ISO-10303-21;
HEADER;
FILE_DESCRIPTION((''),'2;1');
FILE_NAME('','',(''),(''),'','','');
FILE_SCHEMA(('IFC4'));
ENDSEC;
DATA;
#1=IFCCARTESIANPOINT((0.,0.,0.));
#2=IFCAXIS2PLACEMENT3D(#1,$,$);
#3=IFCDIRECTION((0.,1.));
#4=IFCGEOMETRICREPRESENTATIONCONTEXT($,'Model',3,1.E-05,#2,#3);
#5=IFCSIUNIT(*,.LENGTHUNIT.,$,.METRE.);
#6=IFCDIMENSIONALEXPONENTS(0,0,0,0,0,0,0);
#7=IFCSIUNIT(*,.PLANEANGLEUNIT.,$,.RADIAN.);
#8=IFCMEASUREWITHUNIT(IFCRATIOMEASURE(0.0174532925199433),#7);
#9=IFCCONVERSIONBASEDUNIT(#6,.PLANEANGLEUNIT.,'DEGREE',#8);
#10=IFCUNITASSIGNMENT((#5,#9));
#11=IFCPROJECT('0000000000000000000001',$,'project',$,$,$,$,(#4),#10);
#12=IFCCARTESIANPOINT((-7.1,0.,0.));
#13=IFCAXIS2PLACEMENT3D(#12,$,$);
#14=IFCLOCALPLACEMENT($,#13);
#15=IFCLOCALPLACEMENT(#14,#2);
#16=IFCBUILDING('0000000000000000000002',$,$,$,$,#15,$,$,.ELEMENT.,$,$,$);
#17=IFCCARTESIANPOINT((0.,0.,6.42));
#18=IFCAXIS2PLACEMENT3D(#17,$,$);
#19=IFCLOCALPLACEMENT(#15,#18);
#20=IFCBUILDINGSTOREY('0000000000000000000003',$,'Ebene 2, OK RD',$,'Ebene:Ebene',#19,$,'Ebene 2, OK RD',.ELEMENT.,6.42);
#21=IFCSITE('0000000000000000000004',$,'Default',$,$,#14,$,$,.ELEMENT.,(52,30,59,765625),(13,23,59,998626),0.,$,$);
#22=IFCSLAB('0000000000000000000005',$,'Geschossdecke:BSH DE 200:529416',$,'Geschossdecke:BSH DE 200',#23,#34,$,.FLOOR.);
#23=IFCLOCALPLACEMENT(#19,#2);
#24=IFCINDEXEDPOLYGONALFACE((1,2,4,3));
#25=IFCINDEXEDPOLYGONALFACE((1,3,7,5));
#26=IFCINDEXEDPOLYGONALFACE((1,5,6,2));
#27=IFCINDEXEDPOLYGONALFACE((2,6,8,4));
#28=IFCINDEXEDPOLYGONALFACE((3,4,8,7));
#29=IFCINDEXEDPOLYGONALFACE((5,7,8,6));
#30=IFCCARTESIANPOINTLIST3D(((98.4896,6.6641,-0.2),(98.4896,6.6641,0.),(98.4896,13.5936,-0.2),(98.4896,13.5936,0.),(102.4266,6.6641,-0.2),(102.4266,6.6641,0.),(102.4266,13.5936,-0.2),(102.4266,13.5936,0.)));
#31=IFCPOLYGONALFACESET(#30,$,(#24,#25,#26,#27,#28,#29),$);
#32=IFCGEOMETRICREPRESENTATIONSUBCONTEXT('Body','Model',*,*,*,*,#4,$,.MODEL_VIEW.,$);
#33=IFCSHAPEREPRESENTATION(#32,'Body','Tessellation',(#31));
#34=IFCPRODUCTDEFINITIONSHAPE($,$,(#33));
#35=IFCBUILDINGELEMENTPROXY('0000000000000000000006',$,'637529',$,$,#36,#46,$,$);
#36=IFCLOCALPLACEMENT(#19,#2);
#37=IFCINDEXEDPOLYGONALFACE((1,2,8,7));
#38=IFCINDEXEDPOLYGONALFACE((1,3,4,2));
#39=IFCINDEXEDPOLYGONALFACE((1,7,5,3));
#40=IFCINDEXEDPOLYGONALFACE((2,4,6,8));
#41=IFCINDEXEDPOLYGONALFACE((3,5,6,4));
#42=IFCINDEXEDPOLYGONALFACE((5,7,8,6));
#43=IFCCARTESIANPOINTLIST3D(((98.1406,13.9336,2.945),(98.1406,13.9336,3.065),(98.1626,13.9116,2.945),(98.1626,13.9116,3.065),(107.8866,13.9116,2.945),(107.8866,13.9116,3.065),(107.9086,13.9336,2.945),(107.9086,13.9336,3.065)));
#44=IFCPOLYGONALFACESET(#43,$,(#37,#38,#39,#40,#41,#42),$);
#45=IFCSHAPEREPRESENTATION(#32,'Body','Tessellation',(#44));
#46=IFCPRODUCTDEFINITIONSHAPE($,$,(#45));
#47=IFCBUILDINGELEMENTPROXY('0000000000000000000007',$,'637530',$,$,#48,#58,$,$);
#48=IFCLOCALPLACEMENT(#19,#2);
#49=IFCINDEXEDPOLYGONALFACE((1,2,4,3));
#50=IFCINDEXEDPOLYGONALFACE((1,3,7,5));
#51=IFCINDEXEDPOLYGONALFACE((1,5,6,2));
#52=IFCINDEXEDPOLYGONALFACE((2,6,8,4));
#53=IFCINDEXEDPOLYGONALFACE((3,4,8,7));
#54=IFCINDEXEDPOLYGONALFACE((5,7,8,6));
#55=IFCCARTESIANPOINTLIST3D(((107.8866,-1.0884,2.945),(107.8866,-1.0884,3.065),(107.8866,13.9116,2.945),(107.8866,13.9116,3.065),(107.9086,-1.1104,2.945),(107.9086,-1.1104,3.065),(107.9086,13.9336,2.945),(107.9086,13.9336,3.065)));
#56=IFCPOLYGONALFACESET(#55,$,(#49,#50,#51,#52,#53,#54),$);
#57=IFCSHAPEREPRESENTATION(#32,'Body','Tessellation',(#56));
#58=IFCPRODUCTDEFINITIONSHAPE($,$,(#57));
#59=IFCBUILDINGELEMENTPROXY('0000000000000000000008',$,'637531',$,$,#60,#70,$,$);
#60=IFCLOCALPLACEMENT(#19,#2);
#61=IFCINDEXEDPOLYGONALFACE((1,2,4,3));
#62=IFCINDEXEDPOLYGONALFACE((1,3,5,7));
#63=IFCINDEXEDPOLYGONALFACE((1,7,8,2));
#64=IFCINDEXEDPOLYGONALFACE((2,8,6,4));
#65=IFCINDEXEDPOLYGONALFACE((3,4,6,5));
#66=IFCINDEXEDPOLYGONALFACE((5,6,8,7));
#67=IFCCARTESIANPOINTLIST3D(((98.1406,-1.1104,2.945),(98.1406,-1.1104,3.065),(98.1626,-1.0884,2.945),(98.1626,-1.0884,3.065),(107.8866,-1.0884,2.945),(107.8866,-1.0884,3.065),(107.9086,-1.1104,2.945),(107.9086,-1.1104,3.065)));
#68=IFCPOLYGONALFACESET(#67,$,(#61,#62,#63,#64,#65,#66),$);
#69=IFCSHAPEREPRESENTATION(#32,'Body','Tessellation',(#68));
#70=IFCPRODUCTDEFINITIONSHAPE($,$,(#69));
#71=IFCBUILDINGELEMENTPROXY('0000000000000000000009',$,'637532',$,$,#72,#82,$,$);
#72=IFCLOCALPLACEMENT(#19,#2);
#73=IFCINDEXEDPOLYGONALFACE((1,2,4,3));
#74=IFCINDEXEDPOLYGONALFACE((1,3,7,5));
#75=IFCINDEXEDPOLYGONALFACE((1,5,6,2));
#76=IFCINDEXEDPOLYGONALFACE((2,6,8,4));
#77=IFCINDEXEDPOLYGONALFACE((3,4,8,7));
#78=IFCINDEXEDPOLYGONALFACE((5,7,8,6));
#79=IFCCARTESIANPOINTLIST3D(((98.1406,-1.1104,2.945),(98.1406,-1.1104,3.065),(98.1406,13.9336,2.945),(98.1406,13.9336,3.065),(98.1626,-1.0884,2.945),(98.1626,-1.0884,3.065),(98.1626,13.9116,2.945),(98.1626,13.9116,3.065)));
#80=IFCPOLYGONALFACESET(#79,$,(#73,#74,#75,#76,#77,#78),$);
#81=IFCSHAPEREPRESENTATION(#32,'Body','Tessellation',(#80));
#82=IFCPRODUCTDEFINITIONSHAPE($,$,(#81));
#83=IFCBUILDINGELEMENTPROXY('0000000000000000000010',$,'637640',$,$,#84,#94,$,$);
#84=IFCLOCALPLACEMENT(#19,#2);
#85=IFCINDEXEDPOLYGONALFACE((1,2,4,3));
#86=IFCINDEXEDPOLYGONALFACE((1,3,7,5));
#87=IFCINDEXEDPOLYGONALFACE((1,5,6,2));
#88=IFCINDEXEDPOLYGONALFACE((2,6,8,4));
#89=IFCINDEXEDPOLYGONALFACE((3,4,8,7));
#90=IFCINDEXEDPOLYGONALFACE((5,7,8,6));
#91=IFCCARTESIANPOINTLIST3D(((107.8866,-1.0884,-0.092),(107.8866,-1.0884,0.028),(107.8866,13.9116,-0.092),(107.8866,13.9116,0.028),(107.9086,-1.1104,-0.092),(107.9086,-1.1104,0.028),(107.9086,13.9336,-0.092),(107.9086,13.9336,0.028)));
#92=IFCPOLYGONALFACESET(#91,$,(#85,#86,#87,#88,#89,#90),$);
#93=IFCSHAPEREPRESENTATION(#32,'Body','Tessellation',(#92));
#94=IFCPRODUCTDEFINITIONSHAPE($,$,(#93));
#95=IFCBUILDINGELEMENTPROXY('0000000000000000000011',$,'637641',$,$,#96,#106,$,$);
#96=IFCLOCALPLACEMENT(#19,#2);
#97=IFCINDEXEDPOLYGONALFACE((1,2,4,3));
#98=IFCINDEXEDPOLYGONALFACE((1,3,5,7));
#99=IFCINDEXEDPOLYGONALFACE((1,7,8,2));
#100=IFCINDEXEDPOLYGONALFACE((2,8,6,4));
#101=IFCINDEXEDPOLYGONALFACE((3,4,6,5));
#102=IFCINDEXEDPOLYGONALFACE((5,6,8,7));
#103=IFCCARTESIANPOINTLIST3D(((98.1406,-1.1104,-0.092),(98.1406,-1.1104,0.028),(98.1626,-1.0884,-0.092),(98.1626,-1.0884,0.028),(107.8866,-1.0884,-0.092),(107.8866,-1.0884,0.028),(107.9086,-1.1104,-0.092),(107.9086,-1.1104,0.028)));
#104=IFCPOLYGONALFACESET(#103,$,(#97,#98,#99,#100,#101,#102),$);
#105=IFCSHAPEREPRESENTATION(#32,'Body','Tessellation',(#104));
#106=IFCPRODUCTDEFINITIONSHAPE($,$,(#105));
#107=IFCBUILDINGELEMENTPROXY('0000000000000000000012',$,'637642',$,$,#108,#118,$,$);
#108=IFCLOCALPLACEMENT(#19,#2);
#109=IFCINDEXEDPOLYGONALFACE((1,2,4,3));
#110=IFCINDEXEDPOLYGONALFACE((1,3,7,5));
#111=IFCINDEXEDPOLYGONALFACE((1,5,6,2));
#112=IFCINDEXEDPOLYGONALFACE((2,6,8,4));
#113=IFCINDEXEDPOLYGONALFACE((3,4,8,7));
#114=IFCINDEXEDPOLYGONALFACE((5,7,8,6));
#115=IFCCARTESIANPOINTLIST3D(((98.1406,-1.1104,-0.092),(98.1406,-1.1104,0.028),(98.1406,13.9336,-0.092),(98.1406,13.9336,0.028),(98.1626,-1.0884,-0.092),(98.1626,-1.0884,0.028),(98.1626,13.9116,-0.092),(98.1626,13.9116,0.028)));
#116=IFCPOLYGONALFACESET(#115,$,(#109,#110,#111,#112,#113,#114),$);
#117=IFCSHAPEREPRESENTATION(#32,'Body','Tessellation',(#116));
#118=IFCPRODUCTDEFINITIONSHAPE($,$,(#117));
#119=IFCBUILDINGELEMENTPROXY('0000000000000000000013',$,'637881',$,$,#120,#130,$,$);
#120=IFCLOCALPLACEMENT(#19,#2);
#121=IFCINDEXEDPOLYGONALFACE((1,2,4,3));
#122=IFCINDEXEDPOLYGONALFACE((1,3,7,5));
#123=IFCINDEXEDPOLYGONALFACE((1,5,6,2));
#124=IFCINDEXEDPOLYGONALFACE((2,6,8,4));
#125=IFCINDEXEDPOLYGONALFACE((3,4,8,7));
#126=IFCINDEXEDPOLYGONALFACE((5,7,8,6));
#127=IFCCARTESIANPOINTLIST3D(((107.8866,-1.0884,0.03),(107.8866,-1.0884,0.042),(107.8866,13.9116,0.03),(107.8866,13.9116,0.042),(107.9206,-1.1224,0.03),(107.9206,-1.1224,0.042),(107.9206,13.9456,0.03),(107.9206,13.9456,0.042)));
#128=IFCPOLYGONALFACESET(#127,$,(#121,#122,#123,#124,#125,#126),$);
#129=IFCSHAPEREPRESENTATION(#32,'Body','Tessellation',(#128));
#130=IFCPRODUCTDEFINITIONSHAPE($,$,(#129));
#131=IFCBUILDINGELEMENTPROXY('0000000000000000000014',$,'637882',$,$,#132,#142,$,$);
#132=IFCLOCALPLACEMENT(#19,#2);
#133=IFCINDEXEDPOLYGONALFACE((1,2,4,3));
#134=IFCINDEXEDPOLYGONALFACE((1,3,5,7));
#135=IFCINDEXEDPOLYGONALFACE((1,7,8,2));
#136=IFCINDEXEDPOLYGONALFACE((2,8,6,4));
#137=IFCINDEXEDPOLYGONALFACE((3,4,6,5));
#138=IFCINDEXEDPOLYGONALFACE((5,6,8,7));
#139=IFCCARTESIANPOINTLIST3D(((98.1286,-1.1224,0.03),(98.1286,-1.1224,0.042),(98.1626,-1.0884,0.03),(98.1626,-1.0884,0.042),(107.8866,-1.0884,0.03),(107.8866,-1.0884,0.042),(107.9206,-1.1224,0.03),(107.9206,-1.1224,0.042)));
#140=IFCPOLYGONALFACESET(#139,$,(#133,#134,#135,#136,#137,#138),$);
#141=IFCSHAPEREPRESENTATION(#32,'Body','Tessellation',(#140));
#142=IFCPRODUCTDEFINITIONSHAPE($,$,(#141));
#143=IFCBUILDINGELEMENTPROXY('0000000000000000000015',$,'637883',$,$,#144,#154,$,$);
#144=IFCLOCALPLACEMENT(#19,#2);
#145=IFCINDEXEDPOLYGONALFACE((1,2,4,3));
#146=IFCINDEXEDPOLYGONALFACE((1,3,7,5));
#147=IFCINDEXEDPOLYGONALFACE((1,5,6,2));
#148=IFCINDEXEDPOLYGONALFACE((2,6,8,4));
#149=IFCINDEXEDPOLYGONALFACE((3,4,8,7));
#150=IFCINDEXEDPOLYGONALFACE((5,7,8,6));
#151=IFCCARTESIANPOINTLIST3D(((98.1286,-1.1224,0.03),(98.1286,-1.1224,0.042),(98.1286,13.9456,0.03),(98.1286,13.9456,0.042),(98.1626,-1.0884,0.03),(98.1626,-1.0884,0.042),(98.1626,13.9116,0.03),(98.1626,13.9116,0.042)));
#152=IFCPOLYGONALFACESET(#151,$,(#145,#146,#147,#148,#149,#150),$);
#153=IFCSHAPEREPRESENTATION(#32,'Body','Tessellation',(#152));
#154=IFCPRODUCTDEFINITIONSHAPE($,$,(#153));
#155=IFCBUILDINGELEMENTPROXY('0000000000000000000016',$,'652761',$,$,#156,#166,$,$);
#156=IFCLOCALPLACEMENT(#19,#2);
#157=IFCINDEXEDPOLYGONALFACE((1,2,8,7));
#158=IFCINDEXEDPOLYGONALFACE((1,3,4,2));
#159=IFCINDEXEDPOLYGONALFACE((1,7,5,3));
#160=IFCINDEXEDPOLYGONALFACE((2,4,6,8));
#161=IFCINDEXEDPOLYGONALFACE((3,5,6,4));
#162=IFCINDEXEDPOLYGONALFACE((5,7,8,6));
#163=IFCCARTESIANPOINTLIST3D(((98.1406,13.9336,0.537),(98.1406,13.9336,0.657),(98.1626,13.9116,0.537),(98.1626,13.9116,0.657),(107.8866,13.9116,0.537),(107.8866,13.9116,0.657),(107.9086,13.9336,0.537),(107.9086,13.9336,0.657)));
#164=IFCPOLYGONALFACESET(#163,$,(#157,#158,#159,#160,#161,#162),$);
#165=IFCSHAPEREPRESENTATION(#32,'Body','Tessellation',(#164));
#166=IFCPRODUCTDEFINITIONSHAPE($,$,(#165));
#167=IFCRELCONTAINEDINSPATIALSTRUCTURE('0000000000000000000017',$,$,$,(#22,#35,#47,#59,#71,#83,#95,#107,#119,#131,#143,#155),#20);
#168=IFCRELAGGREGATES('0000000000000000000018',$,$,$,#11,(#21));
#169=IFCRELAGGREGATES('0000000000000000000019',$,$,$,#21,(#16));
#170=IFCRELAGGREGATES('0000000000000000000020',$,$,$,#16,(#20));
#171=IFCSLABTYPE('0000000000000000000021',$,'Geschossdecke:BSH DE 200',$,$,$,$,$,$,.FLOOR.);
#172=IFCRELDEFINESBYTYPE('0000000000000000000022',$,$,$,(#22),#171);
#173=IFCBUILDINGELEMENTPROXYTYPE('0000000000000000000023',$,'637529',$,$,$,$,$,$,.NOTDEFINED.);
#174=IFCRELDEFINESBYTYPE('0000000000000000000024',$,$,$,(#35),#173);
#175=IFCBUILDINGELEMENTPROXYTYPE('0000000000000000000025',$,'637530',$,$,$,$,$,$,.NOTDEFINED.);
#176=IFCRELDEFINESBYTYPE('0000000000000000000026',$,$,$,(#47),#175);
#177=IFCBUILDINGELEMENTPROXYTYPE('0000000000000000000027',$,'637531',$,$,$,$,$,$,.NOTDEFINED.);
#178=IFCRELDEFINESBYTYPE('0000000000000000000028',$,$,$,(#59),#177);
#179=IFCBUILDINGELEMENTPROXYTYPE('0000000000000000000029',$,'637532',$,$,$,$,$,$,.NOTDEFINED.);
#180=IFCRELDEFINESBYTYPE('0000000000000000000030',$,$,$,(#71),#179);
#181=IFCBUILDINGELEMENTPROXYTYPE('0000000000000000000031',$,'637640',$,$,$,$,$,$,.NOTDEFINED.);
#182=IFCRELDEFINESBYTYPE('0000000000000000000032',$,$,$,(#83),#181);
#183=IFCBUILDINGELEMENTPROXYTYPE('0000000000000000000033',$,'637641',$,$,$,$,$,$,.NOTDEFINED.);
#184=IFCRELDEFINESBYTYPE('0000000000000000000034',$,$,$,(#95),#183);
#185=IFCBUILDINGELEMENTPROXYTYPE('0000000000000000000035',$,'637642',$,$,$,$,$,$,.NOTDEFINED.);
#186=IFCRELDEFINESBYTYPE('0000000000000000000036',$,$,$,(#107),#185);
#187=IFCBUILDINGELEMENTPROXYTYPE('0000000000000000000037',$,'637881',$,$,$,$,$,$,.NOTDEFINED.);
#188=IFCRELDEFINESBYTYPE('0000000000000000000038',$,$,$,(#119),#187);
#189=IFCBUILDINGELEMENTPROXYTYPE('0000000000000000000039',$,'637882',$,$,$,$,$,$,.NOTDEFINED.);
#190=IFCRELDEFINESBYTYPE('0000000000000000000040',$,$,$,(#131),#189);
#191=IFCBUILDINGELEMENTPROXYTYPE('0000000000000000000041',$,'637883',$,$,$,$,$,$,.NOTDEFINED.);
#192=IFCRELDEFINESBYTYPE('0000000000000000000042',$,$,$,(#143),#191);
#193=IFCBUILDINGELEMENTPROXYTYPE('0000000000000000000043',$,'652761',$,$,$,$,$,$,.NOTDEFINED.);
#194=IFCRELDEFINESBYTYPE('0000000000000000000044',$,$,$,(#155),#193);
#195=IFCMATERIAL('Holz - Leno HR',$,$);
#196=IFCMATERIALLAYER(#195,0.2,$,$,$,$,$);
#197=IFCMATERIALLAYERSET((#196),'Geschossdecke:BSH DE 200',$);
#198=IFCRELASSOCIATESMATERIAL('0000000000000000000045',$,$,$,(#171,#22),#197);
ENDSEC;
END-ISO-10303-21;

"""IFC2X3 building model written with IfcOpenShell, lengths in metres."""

from ifc_helpers import new_model, entity, si_unit, converted_unit, direction, frame, frame_2d, origin, place, context, subcontext, project, spatial, polyline, rectangle, outline, extrude, material, layer, layer_set, layer_usage, type_object, element, save


model = new_model("IFC2X3")

# Units and contexts
model_context = context("Model", 3, precision=1e-05, world=origin(), true_north=direction((0.0, 1.0)))
body_context = subcontext(model_context, "Body", "Model", "MODEL_VIEW")
ifc_project = project(units=[si_unit("LENGTHUNIT", "METRE"), converted_unit("PLANEANGLEUNIT", "DEGREE", entity("IfcRatioMeasure", 0.0174532925199433), si_unit("PLANEANGLEUNIT", "RADIAN"), dimensions=[0, 0, 0, 0, 0, 0, 0])], contexts=[model_context])

# Site, building, storey
site_placement = place(None, frame((-7.1, 0.0, 0.0)))
site = spatial("IfcSite", under=ifc_project, at=site_placement, Name="Default", CompositionType="ELEMENT", RefLatitude=(52, 30, 59, 765625), RefLongitude=(13, 23, 59, 998626), RefElevation=0.0)
building_placement = place(site_placement, origin())
building = spatial("IfcBuilding", under=site, at=building_placement, CompositionType="ELEMENT")
storey_placement = place(building_placement, frame((0.0, 0.0, 6.42)))
storey = spatial("IfcBuildingStorey", under=building, at=storey_placement, Name="Ebene 2, OK RD", ObjectType="Ebene:Ebene", LongName="Ebene 2, OK RD", CompositionType="ELEMENT", Elevation=6.42)

# Slab
ifc_material_1 = material(Name="Holz - Leno HR")
ifc_layer_1 = layer(ifc_material_1, 0.2)
ifc_layer_set_1 = layer_set([ifc_layer_1], Name="Geschossdecke:BSH DE 200")
ifc_layer_usage_1 = layer_usage(ifc_layer_set_1, "AXIS3", "POSITIVE", 0.0)
slab_type_1 = type_object("IfcSlabType", Name="Geschossdecke:BSH DE 200", PredefinedType="FLOOR", material=ifc_layer_set_1)
slab_placement = place(storey_placement, origin())
element("IfcSlab", 1, at=slab_placement, inside=storey, type_object=slab_type_1, material=ifc_layer_usage_1, Name="Geschossdecke:BSH DE 200:529416", ObjectType="Geschossdecke:BSH DE 200", PredefinedType="FLOOR", context=body_context, shape_type="SweptSolid", body=[
    extrude(rectangle(XDim=6.9295, YDim=3.937, at=frame_2d((0.0, 0.0), x_axis=(1.0, 0.0))), frame((100.4581, 10.1289, 0.0), z_axis=(0.0, 0.0, -1.0), x_axis=(0.0, 1.0, 0.0)), (0.0, 0.0, 1.0), 0.2),
])

# Building element proxies
building_element_proxy_type_1 = type_object("IfcBuildingElementProxyType", Name="637529", PredefinedType="NOTDEFINED")
proxy_1_placement = place(storey_placement, origin())
element("IfcBuildingElementProxy", 2, at=proxy_1_placement, inside=storey, type_object=building_element_proxy_type_1, Name="637529", context=body_context, shape_type="SweptSolid", body=[
    extrude(outline(polyline([(-4.862, -0.011), (4.862, -0.011), (4.884, 0.011), (-4.884, 0.011), (-4.862, -0.011)])), frame((103.0246, 13.9226, 2.945)), (0.0, 0.0, 1.0), 0.12),
])
building_element_proxy_type_2 = type_object("IfcBuildingElementProxyType", Name="637530", PredefinedType="NOTDEFINED")
proxy_2_placement = place(storey_placement, origin())
element("IfcBuildingElementProxy", 3, at=proxy_2_placement, inside=storey, type_object=building_element_proxy_type_2, Name="637530", context=body_context, shape_type="SweptSolid", body=[
    extrude(outline(polyline([(-7.5, -0.011), (7.5, -0.011), (7.522, 0.011), (-7.522, 0.011), (-7.5, -0.011)])), frame((107.8976, 6.4116, 2.945), z_axis=(0.0, 0.0, 1.0), x_axis=(0.0, -1.0, 0.0)), (0.0, 0.0, 1.0), 0.12),
])
building_element_proxy_type_3 = type_object("IfcBuildingElementProxyType", Name="637531", PredefinedType="NOTDEFINED")
proxy_3_placement = place(storey_placement, origin())
element("IfcBuildingElementProxy", 4, at=proxy_3_placement, inside=storey, type_object=building_element_proxy_type_3, Name="637531", context=body_context, shape_type="SweptSolid", body=[
    extrude(outline(polyline([(-4.862, -0.011), (4.862, -0.011), (4.884, 0.011), (-4.884, 0.011), (-4.862, -0.011)])), frame((103.0246, -1.0994, 2.945), z_axis=(0.0, 0.0, 1.0), x_axis=(-1.0, 0.0, 0.0)), (0.0, 0.0, 1.0), 0.12),
])
building_element_proxy_type_4 = type_object("IfcBuildingElementProxyType", Name="637532", PredefinedType="NOTDEFINED")
proxy_4_placement = place(storey_placement, origin())
element("IfcBuildingElementProxy", 5, at=proxy_4_placement, inside=storey, type_object=building_element_proxy_type_4, Name="637532", context=body_context, shape_type="SweptSolid", body=[
    extrude(outline(polyline([(-7.5, -0.011), (7.5, -0.011), (7.522, 0.011), (-7.522, 0.011), (-7.5, -0.011)])), frame((98.1516, 6.4116, 2.945), z_axis=(0.0, 0.0, 1.0), x_axis=(0.0, 1.0, 0.0)), (0.0, 0.0, 1.0), 0.12),
])
building_element_proxy_type_5 = type_object("IfcBuildingElementProxyType", Name="637640", PredefinedType="NOTDEFINED")
proxy_5_placement = place(storey_placement, origin())
element("IfcBuildingElementProxy", 6, at=proxy_5_placement, inside=storey, type_object=building_element_proxy_type_5, Name="637640", context=body_context, shape_type="SweptSolid", body=[
    extrude(outline(polyline([(-7.5, -0.011), (7.5, -0.011), (7.522, 0.011), (-7.522, 0.011), (-7.5, -0.011)])), frame((107.8976, 6.4116, -0.092), z_axis=(0.0, 0.0, 1.0), x_axis=(0.0, -1.0, 0.0)), (0.0, 0.0, 1.0), 0.12),
])
building_element_proxy_type_6 = type_object("IfcBuildingElementProxyType", Name="637641", PredefinedType="NOTDEFINED")
proxy_6_placement = place(storey_placement, origin())
element("IfcBuildingElementProxy", 7, at=proxy_6_placement, inside=storey, type_object=building_element_proxy_type_6, Name="637641", context=body_context, shape_type="SweptSolid", body=[
    extrude(outline(polyline([(-4.862, -0.011), (4.862, -0.011), (4.884, 0.011), (-4.884, 0.011), (-4.862, -0.011)])), frame((103.0246, -1.0994, -0.092), z_axis=(0.0, 0.0, 1.0), x_axis=(-1.0, 0.0, 0.0)), (0.0, 0.0, 1.0), 0.12),
])
building_element_proxy_type_7 = type_object("IfcBuildingElementProxyType", Name="637642", PredefinedType="NOTDEFINED")
proxy_7_placement = place(storey_placement, origin())
element("IfcBuildingElementProxy", 8, at=proxy_7_placement, inside=storey, type_object=building_element_proxy_type_7, Name="637642", context=body_context, shape_type="SweptSolid", body=[
    extrude(outline(polyline([(-7.5, -0.011), (7.5, -0.011), (7.522, 0.011), (-7.522, 0.011), (-7.5, -0.011)])), frame((98.1516, 6.4116, -0.092), z_axis=(0.0, 0.0, 1.0), x_axis=(0.0, 1.0, 0.0)), (0.0, 0.0, 1.0), 0.12),
])
building_element_proxy_type_8 = type_object("IfcBuildingElementProxyType", Name="637881", PredefinedType="NOTDEFINED")
proxy_8_placement = place(storey_placement, origin())
element("IfcBuildingElementProxy", 9, at=proxy_8_placement, inside=storey, type_object=building_element_proxy_type_8, Name="637881", context=body_context, shape_type="SweptSolid", body=[
    extrude(outline(polyline([(-7.5, -0.017), (7.5, -0.017), (7.534, 0.017), (-7.534, 0.017), (-7.5, -0.017)])), frame((107.9036, 6.4116, 0.03), z_axis=(0.0, 0.0, 1.0), x_axis=(0.0, -1.0, 0.0)), (0.0, 0.0, 1.0), 0.012),
])
building_element_proxy_type_9 = type_object("IfcBuildingElementProxyType", Name="637882", PredefinedType="NOTDEFINED")
proxy_9_placement = place(storey_placement, origin())
element("IfcBuildingElementProxy", 10, at=proxy_9_placement, inside=storey, type_object=building_element_proxy_type_9, Name="637882", context=body_context, shape_type="SweptSolid", body=[
    extrude(outline(polyline([(-4.862, -0.017), (4.862, -0.017), (4.896, 0.017), (-4.896, 0.017), (-4.862, -0.017)])), frame((103.0246, -1.1054, 0.03), z_axis=(0.0, 0.0, 1.0), x_axis=(-1.0, 0.0, 0.0)), (0.0, 0.0, 1.0), 0.012),
])
building_element_proxy_type_10 = type_object("IfcBuildingElementProxyType", Name="637883", PredefinedType="NOTDEFINED")
proxy_10_placement = place(storey_placement, origin())
element("IfcBuildingElementProxy", 11, at=proxy_10_placement, inside=storey, type_object=building_element_proxy_type_10, Name="637883", context=body_context, shape_type="SweptSolid", body=[
    extrude(outline(polyline([(-7.5, -0.017), (7.5, -0.017), (7.534, 0.017), (-7.534, 0.017), (-7.5, -0.017)])), frame((98.1456, 6.4116, 0.03), z_axis=(0.0, 0.0, 1.0), x_axis=(0.0, 1.0, 0.0)), (0.0, 0.0, 1.0), 0.012),
])
building_element_proxy_type_11 = type_object("IfcBuildingElementProxyType", Name="652761", PredefinedType="NOTDEFINED")
proxy_11_placement = place(storey_placement, origin())
element("IfcBuildingElementProxy", 12, at=proxy_11_placement, inside=storey, type_object=building_element_proxy_type_11, Name="652761", context=body_context, shape_type="SweptSolid", body=[
    extrude(outline(polyline([(-4.862, -0.011), (4.862, -0.011), (4.884, 0.011), (-4.884, 0.011), (-4.862, -0.011)])), frame((103.0246, 13.9226, 0.537)), (0.0, 0.0, 1.0), 0.12),
])

save(model, "model.ifc")
